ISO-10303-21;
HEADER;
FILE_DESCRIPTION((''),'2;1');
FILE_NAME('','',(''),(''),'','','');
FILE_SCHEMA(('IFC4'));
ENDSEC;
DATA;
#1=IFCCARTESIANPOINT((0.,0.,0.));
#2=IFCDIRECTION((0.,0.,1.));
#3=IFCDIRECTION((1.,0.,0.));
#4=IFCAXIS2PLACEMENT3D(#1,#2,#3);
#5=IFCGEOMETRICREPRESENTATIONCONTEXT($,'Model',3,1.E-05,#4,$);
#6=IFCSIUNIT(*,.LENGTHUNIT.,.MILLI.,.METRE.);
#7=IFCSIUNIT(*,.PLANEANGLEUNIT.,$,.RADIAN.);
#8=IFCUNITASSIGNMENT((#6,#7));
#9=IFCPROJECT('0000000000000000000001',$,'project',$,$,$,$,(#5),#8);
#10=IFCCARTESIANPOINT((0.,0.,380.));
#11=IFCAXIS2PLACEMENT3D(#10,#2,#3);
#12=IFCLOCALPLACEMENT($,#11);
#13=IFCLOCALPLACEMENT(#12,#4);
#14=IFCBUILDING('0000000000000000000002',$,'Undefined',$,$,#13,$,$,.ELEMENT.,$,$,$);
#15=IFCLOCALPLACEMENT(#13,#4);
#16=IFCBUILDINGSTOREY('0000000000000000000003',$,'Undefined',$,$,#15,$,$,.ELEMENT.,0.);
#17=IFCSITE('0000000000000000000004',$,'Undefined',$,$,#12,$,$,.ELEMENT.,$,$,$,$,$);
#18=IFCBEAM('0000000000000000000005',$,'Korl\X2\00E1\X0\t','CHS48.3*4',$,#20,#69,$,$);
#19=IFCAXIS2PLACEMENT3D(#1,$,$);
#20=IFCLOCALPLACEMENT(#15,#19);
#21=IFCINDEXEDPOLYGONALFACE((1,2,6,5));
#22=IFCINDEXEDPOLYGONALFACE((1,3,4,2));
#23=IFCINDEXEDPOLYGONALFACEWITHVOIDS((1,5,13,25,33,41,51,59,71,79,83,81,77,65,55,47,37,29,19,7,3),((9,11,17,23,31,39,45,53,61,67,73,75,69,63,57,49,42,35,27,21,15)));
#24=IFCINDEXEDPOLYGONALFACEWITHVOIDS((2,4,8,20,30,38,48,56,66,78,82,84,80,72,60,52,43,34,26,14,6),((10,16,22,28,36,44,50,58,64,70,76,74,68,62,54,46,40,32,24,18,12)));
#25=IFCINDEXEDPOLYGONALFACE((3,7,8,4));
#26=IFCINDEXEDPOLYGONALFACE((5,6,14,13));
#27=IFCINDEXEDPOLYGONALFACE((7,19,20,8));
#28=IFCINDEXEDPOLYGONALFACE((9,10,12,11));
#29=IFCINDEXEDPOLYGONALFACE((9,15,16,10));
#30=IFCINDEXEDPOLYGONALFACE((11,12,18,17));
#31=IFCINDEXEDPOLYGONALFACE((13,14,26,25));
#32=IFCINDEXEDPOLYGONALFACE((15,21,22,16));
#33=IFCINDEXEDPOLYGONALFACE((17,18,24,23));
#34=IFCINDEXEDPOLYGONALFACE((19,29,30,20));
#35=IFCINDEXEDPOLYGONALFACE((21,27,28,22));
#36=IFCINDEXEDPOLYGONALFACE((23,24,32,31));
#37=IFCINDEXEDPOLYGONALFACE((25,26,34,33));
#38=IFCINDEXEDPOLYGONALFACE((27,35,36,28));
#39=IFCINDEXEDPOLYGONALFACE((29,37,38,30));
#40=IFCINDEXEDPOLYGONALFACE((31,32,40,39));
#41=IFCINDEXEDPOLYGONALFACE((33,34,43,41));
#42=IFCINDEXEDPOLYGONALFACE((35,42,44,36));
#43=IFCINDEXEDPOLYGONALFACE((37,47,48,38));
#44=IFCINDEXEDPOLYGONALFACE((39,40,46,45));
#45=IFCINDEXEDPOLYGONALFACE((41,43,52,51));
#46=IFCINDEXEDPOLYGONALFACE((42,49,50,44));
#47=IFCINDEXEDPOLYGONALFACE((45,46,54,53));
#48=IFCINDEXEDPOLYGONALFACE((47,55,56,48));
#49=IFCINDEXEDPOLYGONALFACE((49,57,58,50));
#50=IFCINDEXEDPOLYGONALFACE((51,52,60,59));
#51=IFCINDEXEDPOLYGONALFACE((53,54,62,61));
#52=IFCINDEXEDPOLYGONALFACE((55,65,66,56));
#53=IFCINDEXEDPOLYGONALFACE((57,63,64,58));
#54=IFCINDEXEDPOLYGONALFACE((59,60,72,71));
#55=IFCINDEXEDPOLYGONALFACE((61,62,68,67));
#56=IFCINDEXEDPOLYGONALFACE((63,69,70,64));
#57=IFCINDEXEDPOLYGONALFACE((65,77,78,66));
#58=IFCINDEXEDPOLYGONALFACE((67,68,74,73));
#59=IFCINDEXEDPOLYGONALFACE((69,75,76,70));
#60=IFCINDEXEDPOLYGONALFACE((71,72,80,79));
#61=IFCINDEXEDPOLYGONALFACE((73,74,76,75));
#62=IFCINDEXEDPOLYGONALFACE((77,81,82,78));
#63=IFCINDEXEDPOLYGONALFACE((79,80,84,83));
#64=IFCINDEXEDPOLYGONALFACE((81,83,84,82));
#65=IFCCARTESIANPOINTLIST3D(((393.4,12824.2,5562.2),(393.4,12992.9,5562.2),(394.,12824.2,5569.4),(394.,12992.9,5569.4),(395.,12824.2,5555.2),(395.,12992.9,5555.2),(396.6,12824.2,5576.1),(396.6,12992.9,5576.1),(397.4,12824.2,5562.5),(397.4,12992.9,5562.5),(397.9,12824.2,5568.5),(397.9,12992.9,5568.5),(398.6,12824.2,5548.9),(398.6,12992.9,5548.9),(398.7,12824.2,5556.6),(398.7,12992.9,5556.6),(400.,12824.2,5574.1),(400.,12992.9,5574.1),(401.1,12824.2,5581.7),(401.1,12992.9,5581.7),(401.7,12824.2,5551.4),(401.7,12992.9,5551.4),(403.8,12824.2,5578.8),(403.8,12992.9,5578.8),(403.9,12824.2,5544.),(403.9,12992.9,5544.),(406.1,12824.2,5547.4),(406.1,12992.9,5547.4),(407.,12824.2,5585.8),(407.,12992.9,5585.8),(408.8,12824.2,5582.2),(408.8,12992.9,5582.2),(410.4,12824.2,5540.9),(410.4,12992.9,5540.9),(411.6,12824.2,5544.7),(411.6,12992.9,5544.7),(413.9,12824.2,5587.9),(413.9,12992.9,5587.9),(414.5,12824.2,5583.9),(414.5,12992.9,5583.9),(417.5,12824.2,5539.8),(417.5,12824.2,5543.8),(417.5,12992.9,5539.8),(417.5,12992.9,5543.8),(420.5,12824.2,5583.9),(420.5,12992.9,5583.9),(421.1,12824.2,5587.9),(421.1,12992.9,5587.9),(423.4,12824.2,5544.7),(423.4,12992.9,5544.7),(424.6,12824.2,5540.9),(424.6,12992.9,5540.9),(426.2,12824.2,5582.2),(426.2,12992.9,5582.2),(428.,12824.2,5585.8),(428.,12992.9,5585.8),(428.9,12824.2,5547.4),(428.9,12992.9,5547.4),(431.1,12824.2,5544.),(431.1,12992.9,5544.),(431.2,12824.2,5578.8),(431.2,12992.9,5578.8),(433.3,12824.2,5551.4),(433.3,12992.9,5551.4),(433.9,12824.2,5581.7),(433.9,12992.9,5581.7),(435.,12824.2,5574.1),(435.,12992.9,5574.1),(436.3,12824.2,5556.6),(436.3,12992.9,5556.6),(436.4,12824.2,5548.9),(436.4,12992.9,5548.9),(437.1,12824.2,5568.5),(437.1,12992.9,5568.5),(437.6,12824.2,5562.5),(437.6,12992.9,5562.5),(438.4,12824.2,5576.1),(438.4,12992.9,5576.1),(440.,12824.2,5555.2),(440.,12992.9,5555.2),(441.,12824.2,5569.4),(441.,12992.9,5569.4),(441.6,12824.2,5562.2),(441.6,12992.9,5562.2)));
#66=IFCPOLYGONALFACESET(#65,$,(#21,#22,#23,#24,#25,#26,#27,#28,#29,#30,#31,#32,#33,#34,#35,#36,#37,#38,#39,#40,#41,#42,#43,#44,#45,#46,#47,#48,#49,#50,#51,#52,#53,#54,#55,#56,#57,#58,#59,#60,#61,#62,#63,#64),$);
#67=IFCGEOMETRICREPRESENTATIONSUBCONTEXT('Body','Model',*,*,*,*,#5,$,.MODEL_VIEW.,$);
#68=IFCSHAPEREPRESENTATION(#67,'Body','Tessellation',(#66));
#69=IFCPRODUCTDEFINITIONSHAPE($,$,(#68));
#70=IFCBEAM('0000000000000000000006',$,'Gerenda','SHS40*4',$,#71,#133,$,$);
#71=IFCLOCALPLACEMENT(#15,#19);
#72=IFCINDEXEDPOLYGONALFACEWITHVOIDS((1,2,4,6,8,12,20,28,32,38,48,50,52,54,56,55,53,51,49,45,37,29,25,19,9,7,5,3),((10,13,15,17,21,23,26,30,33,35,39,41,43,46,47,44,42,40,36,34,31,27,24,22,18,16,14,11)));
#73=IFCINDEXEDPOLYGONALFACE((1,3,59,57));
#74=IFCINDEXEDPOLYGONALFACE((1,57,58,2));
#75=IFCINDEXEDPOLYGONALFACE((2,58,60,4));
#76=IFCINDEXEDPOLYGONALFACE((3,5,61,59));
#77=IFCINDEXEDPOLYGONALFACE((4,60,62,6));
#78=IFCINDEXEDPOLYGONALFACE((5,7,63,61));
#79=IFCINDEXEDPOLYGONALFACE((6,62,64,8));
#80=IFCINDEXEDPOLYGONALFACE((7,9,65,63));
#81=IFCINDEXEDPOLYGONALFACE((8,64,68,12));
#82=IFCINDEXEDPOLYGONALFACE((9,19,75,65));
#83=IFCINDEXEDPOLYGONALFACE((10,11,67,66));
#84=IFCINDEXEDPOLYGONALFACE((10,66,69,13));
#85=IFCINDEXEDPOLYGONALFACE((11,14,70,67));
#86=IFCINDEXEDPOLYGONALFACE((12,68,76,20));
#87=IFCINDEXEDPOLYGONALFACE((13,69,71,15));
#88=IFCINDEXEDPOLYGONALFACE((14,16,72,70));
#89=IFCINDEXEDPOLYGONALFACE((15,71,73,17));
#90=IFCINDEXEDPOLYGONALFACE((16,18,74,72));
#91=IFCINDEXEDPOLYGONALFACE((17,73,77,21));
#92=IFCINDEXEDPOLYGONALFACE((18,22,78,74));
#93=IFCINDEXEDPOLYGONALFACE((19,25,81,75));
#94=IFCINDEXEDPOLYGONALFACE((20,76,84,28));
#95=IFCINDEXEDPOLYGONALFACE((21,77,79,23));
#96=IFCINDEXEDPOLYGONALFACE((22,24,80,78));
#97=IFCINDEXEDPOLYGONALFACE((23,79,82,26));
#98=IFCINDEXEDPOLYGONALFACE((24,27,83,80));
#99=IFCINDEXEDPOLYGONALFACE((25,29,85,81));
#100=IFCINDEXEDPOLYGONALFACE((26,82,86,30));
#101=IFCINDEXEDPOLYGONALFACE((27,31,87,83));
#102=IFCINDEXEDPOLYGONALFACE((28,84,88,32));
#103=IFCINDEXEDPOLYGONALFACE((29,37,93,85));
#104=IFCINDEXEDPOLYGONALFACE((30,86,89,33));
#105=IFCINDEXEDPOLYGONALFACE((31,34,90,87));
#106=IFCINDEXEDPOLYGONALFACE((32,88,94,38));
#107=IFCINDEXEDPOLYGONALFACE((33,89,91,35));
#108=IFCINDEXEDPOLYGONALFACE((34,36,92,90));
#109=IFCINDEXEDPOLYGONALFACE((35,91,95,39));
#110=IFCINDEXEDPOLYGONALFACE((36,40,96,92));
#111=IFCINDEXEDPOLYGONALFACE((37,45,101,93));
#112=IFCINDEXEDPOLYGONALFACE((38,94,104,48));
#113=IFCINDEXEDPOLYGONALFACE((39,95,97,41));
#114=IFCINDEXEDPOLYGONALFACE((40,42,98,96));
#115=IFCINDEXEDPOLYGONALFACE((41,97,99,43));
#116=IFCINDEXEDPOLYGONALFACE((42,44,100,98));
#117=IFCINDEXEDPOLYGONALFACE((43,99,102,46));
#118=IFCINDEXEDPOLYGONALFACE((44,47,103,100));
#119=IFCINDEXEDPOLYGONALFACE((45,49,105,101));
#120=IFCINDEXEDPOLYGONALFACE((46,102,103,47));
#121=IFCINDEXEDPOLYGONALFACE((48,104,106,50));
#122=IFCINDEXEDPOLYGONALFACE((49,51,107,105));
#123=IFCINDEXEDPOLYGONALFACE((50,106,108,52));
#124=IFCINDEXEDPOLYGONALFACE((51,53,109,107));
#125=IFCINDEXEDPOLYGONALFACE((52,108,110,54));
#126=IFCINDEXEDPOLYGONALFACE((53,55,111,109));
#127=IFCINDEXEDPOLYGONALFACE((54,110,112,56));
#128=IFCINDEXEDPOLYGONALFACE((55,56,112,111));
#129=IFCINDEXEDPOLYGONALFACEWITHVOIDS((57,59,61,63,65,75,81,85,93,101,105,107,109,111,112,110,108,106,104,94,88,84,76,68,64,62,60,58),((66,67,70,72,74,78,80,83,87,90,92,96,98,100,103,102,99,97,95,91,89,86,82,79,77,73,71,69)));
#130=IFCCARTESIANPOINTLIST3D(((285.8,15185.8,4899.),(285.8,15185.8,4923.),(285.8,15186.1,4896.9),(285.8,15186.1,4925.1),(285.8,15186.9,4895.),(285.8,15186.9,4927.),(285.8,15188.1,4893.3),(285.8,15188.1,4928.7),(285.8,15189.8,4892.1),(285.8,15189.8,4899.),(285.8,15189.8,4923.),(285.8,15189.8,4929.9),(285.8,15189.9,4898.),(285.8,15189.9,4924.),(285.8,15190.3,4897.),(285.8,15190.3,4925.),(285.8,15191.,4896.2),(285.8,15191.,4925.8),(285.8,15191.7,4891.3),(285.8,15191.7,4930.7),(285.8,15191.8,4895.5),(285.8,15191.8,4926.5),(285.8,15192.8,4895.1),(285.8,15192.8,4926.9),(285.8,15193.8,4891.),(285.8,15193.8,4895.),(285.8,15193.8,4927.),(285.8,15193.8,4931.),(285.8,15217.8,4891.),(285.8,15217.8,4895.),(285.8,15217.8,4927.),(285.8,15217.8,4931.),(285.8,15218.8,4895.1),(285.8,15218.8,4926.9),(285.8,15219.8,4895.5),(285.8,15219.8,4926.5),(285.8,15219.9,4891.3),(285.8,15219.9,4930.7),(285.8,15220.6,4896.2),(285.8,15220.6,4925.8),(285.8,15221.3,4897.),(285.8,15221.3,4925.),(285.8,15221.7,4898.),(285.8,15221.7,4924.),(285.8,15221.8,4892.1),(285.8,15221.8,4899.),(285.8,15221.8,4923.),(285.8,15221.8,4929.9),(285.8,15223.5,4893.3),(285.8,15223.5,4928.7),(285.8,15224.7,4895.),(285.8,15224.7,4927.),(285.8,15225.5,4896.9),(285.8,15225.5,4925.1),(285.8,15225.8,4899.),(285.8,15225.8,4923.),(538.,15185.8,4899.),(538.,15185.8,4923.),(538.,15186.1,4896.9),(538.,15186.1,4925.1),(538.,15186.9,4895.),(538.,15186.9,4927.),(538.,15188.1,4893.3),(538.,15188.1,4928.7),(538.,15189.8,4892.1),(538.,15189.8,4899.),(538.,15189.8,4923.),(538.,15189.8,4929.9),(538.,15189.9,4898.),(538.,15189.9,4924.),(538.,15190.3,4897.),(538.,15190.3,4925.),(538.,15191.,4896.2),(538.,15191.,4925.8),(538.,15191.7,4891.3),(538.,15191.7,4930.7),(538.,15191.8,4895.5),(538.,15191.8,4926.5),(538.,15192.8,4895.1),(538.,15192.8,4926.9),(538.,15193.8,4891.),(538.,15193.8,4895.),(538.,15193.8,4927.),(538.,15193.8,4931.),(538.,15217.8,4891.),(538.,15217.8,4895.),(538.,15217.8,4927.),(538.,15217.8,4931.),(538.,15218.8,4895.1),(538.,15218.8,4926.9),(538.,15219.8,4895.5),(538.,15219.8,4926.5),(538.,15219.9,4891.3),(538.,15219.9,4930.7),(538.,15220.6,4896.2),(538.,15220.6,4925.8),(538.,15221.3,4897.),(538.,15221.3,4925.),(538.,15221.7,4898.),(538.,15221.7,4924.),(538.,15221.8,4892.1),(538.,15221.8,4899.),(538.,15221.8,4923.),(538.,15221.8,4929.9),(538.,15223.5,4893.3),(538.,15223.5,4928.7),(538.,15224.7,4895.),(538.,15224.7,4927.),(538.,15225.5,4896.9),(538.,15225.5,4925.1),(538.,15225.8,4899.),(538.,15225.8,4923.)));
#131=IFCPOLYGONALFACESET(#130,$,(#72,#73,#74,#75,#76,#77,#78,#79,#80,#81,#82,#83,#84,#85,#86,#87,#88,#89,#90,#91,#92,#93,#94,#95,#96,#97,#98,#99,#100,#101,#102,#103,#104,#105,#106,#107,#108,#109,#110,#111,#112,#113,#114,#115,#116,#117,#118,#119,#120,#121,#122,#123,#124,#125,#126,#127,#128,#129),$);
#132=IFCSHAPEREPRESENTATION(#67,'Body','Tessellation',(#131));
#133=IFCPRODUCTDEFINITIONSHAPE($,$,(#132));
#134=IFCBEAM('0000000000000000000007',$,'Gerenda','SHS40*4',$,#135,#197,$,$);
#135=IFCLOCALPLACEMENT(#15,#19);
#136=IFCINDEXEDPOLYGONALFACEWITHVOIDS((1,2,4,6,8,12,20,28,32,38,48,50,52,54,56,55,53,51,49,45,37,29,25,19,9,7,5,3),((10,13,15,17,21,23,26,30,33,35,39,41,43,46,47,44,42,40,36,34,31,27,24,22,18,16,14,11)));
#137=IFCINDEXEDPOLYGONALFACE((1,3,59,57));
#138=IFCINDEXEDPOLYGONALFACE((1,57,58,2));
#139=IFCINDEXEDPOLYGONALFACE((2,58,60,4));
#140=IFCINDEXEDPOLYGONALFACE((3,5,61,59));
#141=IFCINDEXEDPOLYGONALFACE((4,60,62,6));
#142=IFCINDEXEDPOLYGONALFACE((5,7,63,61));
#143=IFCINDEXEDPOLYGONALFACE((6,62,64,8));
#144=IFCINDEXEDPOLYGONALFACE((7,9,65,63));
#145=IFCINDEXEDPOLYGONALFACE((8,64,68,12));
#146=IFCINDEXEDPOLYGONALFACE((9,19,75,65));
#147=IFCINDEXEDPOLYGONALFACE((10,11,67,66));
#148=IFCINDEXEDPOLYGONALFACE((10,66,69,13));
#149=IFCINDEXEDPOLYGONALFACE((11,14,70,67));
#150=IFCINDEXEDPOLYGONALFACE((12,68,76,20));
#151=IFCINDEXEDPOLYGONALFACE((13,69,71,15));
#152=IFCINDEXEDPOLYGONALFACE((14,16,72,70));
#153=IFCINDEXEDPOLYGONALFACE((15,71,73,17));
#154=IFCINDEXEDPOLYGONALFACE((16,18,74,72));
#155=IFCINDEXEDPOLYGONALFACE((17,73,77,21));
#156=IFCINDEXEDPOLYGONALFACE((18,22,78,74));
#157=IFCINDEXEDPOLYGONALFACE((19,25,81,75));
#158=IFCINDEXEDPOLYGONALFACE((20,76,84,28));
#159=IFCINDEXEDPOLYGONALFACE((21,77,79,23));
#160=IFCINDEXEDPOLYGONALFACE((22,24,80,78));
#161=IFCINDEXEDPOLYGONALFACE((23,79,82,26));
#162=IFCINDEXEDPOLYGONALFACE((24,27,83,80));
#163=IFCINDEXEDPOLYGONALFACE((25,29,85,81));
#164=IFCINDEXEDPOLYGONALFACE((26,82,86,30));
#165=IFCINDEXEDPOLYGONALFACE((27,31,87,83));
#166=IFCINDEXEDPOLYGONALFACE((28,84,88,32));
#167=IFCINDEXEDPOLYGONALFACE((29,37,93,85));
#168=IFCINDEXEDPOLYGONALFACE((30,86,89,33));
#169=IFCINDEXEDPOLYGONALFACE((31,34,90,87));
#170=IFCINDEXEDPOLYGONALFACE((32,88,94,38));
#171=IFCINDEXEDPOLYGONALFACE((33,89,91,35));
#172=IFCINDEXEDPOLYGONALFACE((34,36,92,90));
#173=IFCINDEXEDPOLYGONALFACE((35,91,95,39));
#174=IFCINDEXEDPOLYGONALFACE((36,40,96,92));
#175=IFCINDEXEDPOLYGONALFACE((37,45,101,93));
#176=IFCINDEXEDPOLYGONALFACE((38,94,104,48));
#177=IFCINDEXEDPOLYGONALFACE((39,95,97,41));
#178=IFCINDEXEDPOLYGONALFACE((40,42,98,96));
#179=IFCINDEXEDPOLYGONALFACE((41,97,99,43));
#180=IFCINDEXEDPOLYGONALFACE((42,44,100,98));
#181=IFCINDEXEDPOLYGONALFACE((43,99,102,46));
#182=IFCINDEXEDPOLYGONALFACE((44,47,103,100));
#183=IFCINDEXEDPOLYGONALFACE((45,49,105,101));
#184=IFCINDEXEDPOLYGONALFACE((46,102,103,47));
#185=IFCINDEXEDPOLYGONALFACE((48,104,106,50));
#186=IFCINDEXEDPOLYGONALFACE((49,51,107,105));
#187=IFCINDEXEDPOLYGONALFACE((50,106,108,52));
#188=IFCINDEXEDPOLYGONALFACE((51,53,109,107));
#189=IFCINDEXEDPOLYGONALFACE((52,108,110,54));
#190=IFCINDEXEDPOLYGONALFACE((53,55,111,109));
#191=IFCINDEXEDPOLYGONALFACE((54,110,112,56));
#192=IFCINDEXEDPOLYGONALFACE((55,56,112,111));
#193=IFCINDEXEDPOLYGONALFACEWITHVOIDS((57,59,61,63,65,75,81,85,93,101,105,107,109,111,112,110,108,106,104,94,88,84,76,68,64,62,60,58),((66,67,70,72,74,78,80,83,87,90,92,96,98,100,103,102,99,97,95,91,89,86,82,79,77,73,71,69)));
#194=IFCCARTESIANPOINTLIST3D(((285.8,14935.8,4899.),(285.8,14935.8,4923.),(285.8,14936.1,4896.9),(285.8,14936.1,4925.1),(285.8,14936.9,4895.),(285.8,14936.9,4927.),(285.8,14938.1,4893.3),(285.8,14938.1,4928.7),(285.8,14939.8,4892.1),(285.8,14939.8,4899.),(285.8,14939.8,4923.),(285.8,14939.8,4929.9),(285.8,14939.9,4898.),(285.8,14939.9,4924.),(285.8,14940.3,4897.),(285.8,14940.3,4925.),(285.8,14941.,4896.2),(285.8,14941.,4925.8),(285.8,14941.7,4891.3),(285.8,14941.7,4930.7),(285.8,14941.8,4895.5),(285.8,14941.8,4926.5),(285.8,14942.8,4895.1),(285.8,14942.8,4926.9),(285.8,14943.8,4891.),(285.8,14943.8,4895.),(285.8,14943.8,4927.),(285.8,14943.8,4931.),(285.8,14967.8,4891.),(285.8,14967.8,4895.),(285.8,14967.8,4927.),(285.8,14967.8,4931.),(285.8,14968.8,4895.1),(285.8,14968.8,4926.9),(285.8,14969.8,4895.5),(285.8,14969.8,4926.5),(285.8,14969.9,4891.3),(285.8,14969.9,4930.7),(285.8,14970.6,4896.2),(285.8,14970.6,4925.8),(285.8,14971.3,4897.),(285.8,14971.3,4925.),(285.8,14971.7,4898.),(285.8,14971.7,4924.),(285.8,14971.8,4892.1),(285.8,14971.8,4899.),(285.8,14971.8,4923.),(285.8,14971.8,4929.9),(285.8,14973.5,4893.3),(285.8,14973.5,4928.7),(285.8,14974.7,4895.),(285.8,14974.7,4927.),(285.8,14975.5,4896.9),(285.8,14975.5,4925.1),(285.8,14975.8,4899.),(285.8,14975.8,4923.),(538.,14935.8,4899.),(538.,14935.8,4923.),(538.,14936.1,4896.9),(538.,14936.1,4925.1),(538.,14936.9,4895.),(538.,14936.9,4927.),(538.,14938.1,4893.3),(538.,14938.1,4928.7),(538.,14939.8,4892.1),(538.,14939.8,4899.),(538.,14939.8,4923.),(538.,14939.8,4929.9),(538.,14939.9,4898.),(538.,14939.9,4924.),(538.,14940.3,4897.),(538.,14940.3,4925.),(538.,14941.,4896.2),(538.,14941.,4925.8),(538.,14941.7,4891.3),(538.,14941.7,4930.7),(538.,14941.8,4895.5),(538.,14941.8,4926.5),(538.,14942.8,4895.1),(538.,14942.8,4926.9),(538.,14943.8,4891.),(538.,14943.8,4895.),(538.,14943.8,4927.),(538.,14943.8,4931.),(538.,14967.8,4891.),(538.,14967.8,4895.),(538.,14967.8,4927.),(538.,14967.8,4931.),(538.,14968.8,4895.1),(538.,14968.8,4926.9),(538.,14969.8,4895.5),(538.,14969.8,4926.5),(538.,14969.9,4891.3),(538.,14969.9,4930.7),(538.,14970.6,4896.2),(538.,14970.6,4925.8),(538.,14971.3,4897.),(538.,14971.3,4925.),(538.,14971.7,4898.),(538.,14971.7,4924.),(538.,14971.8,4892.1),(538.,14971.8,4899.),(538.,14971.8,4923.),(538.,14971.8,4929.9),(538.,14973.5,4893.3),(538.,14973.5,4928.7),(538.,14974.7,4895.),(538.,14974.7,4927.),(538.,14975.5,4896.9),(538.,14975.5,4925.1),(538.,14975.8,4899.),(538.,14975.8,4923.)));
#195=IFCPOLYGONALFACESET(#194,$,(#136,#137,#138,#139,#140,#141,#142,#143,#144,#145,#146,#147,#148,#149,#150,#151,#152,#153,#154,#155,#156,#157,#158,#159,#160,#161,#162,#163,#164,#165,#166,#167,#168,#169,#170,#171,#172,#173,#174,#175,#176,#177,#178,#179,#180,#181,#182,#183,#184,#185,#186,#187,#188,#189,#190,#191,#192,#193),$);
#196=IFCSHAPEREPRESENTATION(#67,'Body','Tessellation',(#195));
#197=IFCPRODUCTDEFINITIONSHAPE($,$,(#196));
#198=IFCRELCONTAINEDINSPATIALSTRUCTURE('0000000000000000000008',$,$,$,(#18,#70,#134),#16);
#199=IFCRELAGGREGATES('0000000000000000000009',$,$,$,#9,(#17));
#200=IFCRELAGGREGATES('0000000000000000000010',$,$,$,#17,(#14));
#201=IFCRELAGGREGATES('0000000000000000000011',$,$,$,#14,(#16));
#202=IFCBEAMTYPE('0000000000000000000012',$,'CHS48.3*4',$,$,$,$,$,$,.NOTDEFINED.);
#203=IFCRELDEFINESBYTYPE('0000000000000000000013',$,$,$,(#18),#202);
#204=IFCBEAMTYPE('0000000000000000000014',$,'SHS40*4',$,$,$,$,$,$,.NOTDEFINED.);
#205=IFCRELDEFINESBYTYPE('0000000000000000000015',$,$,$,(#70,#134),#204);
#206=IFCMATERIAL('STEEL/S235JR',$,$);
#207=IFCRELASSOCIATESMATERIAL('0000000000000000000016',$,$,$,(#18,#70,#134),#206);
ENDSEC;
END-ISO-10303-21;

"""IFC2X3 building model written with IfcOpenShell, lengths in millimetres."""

from ifc_helpers import new_model, si_unit, frame, origin_with_axes, origin_2d_with_axis, place, context, subcontext, project, spatial, hollow_rectangle, hollow_circle, extrude, clip, halfspace, material, type_object, element, save


model = new_model("IFC2X3")

# Units and contexts
model_context = context("Model", 3, precision=1e-05, world=origin_with_axes())
body_context = subcontext(model_context, "Body", "Model", "MODEL_VIEW")
ifc_project = project(units=[si_unit("LENGTHUNIT", "METRE", prefix="MILLI"), si_unit("PLANEANGLEUNIT", "RADIAN")], contexts=[model_context])

# Site, building, storey
site_placement = place(None, frame((0.0, 0.0, 380.0), z_axis=(0.0, 0.0, 1.0), x_axis=(1.0, 0.0, 0.0)))
site = spatial("IfcSite", under=ifc_project, at=site_placement, Name="Undefined", CompositionType="ELEMENT")
building_placement = place(site_placement, origin_with_axes())
building = spatial("IfcBuilding", under=site, at=building_placement, Name="Undefined", CompositionType="ELEMENT")
storey_placement = place(building_placement, origin_with_axes())
storey = spatial("IfcBuildingStorey", under=building, at=storey_placement, Name="Undefined", CompositionType="ELEMENT", Elevation=0.0)

# Shared definitions
ifc_material_1 = material(Name="STEEL/S235JR")

# Beams
beam_type_1 = type_object("IfcBeamType", Name="CHS48.3*4", PredefinedType="NOTDEFINED")
beam_1_placement = place(storey_placement, frame((417.5, 12824.1, 5564.0), z_axis=(1.0, 0.0, 0.0), x_axis=(0.0, 1.0, 0.0)))
element("IfcBeam", 1, at=beam_1_placement, inside=storey, type_object=beam_type_1, material=ifc_material_1, Name="Korlát", Description="CHS48.3*4", context=body_context, shape_type="SweptSolid", body=[
    extrude(hollow_circle(Radius=24.1, WallThickness=4.0, at=origin_2d_with_axis()), frame((168.8, 0.0, 0.0), z_axis=(-1.0, 0.0, 0.0), x_axis=(0.0, -1.0, 0.0)), (0.0, 0.0, 1.0), 168.8),
])
beam_type_2 = type_object("IfcBeamType", Name="SHS40*4", PredefinedType="NOTDEFINED")
for number, where, z_axis, x_axis, name in (
    (2, (285.8, 15205.8, 4911.0), (0.0, 1.0, 0.0), (1.0, 0.0, 0.0), "Gerenda"),
    (3, (285.8, 14955.8, 4911.0), (0.0, 1.0, 0.0), (1.0, 0.0, 0.0), "Gerenda"),
):
    element("IfcBeam", number, at=place(storey_placement, frame(where, z_axis=z_axis, x_axis=x_axis)), inside=storey, type_object=beam_type_2, material=ifc_material_1, Name=name, Description="SHS40*4", context=body_context, shape_type="Clipping", body=[
        clip(extrude(hollow_rectangle(XDim=40.0, YDim=40.0, WallThickness=4.0, InnerFilletRadius=4.0, OuterFilletRadius=8.0, at=origin_2d_with_axis()), frame((252.2, 0.0, 0.0), z_axis=(-1.0, 0.0, 0.0), x_axis=(0.0, -1.0, 0.0)), (0.0, 0.0, 1.0), 252.2), halfspace(frame((0.0, 0.0, -20.0), z_axis=(1.0, 0.0, 0.0), x_axis=(0.0, -1.0, 0.0)), True)),
    ])

save(model, "model.ifc")
